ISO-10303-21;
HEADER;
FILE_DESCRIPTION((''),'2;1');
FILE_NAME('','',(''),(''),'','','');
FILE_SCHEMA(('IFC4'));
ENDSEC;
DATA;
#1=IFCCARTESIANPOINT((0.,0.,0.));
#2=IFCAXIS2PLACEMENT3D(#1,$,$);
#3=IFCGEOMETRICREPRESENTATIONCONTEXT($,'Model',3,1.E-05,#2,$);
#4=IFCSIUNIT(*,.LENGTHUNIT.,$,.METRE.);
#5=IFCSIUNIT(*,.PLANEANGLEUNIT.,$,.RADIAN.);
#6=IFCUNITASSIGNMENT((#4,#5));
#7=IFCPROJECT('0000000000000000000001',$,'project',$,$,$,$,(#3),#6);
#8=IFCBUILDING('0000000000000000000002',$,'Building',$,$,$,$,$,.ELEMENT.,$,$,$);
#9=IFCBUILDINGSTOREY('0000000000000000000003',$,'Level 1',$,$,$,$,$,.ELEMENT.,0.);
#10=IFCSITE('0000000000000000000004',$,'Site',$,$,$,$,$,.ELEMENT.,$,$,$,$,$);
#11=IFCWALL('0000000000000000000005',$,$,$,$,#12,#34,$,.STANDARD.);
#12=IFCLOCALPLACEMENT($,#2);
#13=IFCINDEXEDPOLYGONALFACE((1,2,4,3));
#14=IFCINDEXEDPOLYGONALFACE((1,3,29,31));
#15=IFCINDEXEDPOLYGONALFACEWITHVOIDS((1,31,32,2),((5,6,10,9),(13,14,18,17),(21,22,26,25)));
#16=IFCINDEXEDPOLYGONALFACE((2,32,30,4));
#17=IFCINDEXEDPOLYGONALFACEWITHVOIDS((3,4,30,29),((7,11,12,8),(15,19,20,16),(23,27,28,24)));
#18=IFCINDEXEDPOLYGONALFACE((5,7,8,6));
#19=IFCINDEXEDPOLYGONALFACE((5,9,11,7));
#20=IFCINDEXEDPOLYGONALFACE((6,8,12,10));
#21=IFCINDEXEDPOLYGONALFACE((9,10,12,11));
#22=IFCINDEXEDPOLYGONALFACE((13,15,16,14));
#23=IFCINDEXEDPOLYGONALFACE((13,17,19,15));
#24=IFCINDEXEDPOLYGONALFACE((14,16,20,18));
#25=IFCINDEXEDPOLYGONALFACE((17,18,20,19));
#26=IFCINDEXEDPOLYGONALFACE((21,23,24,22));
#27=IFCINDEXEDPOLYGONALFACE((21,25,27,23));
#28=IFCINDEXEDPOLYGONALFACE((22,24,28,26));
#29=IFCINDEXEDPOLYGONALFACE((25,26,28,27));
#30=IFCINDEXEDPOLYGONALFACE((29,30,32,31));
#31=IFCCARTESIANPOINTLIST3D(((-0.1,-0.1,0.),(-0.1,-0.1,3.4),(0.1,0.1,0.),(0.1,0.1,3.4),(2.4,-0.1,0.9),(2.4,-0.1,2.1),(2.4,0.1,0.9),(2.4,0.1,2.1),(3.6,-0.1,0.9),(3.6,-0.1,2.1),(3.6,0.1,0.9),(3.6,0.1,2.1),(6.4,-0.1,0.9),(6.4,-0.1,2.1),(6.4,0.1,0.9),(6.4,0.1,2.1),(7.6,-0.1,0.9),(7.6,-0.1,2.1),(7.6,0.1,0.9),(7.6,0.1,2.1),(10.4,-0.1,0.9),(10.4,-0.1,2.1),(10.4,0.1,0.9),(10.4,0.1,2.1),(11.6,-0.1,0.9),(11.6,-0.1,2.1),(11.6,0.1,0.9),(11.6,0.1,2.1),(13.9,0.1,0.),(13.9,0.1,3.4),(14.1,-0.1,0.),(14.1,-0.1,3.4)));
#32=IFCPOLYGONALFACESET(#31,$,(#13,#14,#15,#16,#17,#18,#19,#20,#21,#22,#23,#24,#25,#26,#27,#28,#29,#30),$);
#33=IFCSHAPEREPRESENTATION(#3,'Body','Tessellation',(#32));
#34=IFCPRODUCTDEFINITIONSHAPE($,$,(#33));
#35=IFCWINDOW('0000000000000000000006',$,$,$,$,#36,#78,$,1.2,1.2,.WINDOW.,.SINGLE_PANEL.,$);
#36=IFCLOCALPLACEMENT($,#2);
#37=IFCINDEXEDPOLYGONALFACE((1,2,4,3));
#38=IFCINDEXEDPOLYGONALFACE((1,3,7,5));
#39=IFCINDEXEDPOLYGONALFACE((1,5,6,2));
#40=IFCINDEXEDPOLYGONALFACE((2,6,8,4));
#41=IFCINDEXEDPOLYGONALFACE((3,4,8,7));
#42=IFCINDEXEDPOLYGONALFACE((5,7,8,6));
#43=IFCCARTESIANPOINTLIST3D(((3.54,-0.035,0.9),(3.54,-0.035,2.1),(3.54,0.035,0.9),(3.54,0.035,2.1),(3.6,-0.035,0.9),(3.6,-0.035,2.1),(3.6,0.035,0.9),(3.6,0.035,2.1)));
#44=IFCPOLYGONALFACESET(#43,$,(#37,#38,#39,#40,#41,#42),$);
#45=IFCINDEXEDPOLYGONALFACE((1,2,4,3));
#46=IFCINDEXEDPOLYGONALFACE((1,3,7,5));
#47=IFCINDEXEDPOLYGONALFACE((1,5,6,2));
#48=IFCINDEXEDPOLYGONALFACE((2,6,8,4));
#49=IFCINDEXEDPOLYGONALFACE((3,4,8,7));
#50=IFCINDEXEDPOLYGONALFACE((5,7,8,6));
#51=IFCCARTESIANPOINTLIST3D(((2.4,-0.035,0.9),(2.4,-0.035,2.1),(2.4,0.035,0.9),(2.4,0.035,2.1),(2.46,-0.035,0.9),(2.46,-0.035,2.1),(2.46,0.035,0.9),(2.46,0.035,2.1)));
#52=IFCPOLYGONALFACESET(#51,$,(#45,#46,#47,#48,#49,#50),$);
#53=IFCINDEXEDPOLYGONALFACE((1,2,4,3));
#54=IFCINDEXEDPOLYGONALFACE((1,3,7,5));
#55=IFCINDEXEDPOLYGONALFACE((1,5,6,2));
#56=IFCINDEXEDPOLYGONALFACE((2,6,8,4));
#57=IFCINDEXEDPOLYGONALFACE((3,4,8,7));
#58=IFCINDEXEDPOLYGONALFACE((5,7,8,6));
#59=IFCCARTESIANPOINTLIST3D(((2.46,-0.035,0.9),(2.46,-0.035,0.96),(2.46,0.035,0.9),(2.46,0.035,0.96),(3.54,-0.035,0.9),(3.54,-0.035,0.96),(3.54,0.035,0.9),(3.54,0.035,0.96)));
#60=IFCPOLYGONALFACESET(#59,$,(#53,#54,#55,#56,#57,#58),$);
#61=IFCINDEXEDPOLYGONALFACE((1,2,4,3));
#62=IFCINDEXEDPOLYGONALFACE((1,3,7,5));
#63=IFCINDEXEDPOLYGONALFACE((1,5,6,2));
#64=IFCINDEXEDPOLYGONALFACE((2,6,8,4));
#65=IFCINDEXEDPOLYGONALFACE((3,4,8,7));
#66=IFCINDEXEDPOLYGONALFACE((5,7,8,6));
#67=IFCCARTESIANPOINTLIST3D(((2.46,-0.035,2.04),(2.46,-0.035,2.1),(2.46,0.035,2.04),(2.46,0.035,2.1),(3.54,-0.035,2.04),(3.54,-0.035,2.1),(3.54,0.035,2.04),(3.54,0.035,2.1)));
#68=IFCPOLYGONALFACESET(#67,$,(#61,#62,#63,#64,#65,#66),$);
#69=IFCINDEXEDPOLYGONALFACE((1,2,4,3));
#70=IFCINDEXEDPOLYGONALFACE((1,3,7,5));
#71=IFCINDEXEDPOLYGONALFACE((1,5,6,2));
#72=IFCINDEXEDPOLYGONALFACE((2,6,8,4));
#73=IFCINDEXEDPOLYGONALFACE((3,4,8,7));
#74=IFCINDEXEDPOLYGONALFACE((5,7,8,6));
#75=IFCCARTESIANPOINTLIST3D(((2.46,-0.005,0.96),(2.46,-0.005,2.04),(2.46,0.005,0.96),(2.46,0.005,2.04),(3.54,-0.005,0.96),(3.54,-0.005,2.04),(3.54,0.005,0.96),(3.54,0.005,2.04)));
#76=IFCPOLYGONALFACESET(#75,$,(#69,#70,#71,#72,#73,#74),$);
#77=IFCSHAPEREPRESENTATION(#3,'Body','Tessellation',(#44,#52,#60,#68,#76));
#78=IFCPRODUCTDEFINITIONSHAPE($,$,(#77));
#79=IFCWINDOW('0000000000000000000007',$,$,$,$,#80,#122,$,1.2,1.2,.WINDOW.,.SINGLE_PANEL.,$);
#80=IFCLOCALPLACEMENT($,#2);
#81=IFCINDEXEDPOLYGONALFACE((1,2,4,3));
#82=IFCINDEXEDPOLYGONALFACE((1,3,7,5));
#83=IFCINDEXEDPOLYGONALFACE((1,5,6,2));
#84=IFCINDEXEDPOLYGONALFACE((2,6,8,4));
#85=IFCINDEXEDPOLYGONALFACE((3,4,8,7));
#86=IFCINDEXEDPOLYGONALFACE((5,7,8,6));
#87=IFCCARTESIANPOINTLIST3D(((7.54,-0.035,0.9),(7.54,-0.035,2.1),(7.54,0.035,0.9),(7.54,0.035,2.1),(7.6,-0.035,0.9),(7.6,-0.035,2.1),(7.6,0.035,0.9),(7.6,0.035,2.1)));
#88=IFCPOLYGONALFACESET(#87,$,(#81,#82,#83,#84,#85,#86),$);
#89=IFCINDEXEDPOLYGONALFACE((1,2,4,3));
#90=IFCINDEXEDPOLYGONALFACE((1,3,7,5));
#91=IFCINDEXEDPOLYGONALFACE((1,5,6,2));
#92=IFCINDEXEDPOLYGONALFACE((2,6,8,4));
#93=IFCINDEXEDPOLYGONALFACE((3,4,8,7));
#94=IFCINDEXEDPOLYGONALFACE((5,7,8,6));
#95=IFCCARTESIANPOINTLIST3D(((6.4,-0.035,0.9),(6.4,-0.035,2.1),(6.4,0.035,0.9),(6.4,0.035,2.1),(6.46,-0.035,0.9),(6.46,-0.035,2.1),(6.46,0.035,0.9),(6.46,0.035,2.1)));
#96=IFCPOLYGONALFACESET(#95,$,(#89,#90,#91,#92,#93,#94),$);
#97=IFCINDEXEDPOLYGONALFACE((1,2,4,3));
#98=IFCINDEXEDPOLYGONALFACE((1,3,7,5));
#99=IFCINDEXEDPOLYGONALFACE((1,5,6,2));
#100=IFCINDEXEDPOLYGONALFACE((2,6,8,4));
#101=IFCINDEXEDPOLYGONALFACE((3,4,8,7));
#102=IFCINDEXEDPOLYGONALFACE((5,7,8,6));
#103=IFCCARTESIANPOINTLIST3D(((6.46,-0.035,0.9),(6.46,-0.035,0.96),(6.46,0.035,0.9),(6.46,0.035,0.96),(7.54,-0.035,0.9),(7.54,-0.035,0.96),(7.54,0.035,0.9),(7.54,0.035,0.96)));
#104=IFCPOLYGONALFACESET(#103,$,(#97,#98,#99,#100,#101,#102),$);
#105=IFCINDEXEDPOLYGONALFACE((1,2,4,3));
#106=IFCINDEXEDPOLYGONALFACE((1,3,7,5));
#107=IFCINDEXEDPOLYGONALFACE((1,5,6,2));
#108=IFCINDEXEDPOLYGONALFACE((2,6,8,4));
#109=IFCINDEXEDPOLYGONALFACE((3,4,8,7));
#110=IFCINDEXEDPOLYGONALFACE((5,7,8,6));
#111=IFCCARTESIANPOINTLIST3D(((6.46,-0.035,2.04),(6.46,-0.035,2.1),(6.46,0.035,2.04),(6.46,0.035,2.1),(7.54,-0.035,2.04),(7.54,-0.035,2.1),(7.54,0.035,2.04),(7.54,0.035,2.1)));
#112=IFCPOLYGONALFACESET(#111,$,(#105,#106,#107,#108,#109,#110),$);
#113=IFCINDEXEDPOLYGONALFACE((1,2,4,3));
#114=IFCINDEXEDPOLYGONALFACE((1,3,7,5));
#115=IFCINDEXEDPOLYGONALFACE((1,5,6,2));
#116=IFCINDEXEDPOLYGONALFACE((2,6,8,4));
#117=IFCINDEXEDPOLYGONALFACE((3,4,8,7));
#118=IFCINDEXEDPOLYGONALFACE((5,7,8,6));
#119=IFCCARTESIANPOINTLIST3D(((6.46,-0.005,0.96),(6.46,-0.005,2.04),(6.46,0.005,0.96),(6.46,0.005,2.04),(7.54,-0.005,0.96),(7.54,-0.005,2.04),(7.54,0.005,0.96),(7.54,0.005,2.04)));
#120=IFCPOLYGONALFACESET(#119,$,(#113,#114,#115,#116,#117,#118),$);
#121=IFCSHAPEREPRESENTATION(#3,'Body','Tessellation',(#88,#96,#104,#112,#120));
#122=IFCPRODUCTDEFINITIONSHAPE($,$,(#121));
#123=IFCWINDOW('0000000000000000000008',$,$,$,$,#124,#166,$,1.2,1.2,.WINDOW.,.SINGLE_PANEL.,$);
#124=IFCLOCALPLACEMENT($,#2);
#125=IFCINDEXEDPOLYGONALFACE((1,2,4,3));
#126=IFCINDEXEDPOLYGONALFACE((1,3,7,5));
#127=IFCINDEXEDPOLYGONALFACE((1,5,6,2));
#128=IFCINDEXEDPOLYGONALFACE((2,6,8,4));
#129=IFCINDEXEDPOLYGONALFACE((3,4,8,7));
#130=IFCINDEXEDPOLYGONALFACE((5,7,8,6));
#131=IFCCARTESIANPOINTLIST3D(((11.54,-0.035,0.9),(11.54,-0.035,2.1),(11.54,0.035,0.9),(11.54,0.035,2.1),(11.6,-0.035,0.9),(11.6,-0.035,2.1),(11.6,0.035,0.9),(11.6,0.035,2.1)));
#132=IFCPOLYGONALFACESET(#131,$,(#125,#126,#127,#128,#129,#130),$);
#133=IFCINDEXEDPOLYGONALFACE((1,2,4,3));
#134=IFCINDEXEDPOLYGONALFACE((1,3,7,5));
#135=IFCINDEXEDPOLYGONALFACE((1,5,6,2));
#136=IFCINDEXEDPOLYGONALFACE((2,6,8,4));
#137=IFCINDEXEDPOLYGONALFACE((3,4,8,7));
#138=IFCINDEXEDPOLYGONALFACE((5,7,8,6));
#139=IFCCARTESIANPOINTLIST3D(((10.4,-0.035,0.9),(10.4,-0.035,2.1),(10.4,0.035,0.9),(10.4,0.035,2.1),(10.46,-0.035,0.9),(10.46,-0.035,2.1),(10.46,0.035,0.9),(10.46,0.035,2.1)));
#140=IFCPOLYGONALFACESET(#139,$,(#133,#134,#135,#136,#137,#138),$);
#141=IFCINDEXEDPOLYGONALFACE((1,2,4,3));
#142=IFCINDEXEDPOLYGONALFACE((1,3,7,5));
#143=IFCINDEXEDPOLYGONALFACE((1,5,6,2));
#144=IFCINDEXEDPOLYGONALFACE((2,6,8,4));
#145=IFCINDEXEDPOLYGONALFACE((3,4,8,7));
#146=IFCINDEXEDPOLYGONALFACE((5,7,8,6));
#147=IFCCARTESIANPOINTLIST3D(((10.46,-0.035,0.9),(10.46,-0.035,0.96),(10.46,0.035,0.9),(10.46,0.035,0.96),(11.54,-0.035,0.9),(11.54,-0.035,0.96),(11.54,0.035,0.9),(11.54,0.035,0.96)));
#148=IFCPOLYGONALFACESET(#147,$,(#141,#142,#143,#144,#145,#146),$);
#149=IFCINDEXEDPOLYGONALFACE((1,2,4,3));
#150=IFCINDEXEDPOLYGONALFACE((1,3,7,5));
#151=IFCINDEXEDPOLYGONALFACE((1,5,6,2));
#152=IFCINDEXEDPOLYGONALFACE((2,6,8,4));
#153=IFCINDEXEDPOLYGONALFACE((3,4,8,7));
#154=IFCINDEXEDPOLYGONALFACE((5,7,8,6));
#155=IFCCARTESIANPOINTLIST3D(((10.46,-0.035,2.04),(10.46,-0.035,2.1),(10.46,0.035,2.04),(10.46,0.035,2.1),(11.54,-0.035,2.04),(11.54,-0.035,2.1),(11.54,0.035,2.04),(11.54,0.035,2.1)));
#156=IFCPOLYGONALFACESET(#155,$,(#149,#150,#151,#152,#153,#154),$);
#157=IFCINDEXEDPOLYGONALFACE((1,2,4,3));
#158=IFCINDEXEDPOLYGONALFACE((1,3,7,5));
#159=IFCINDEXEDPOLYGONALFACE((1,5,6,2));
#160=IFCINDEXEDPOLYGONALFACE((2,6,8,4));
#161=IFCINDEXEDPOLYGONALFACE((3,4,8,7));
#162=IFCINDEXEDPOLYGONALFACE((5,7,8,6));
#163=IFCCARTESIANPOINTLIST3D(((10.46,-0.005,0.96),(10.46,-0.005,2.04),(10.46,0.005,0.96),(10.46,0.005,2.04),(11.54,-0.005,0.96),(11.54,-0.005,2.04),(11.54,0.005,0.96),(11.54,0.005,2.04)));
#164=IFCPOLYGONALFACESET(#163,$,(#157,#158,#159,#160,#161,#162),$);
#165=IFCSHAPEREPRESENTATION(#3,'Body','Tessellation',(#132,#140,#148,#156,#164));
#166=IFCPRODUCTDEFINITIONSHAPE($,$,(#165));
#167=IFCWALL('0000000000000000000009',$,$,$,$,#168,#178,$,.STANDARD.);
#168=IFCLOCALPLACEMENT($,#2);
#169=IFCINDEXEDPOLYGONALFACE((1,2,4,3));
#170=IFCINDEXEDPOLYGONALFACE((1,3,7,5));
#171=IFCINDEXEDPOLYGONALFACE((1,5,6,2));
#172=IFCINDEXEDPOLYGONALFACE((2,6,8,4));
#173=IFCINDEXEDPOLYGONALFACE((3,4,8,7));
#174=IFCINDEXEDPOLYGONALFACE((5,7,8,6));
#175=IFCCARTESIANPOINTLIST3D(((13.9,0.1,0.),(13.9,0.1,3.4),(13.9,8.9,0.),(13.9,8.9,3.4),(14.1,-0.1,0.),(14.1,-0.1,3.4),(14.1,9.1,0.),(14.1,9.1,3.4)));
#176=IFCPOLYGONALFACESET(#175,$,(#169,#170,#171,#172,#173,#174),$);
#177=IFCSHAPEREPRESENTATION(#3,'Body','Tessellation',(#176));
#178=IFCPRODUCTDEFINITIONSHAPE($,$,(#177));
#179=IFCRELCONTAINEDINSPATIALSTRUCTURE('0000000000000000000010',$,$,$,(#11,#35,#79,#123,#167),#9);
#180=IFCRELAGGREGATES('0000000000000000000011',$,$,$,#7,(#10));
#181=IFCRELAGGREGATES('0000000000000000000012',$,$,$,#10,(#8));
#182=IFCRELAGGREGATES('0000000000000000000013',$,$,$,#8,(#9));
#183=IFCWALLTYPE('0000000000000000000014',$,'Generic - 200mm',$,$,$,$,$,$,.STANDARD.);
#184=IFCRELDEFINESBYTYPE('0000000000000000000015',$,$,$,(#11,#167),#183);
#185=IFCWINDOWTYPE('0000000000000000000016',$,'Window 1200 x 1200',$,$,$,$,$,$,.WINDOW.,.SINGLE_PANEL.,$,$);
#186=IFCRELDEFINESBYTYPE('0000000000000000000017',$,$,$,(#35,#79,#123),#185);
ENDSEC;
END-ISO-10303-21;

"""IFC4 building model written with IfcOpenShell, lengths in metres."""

from ifc_helpers import new_model, si_unit, frame, frame_2d, origin, origin_with_axes, origin_2d, place, context, project, spatial, polyline, rectangle, outline, extrude, type_object, element, fill, save


model = new_model("IFC4")

# Units and contexts
model_context = context("Model", 3, precision=1e-05, world=origin())
ifc_project = project(units=[si_unit("LENGTHUNIT", "METRE"), si_unit("PLANEANGLEUNIT", "RADIAN")], contexts=[model_context])

# Site, building, storey
site = spatial("IfcSite", under=ifc_project, Name="Site", CompositionType="ELEMENT")
building = spatial("IfcBuilding", under=site, Name="Building", CompositionType="ELEMENT")
storey = spatial("IfcBuildingStorey", under=building, Name="Level 1", CompositionType="ELEMENT", Elevation=0.0)

# Wall, openings, windows
wall_type = type_object("IfcWallType", Name="Generic - 200mm", PredefinedType="STANDARD")
wall_1_placement = place(None, frame((14.0, 0.0, 0.0), z_axis=(0.0, 0.0, 1.0), x_axis=(-1.0, 0.0, 0.0)))
wall_1 = element("IfcWall", 1, at=wall_1_placement, inside=storey, type_object=wall_type, PredefinedType="STANDARD", context=model_context, shape_type="SweptSolid", body=[
    extrude(outline(polyline([(0.1, -0.1), (13.9, -0.1), (14.1, 0.1), (-0.1, 0.1), (0.1, -0.1)])), origin(), (0.0, 0.0, 1.0), 3.4),
])
opening_1_placement = place(wall_1_placement, frame((11.0, 0.0, 0.9), z_axis=(0.0, 0.0, 1.0), x_axis=(1.0, 0.0, 0.0)))
opening_1 = element("IfcOpeningElement", 2, at=opening_1_placement, cuts=wall_1, PredefinedType="OPENING", context=model_context, shape_type="SweptSolid", body=[
    extrude(rectangle(XDim=1.2, YDim=0.202, at=origin_2d()), origin(), (0.0, 0.0, 1.0), 1.2),
])
opening_2_placement = place(wall_1_placement, frame((7.0, 0.0, 0.9), z_axis=(0.0, 0.0, 1.0), x_axis=(1.0, 0.0, 0.0)))
opening_2 = element("IfcOpeningElement", 3, at=opening_2_placement, cuts=wall_1, PredefinedType="OPENING", context=model_context, shape_type="SweptSolid", body=[
    extrude(rectangle(XDim=1.2, YDim=0.202, at=origin_2d()), origin(), (0.0, 0.0, 1.0), 1.2),
])
opening_3_placement = place(wall_1_placement, frame((3.0, 0.0, 0.9), z_axis=(0.0, 0.0, 1.0), x_axis=(1.0, 0.0, 0.0)))
opening_3 = element("IfcOpeningElement", 4, at=opening_3_placement, cuts=wall_1, PredefinedType="OPENING", context=model_context, shape_type="SweptSolid", body=[
    extrude(rectangle(XDim=1.2, YDim=0.202, at=origin_2d()), origin(), (0.0, 0.0, 1.0), 1.2),
])
window_type = type_object("IfcWindowType", Name="Window 1200 x 1200", PartitioningType="SINGLE_PANEL", PredefinedType="WINDOW")
window_1_placement = place(opening_1_placement, origin_with_axes())
window_1 = element("IfcWindow", 5, at=window_1_placement, inside=storey, type_object=window_type, OverallHeight=1.2, OverallWidth=1.2, PartitioningType="SINGLE_PANEL", PredefinedType="WINDOW", context=model_context, shape_type="SweptSolid", body=[
    extrude(rectangle(XDim=0.06, YDim=0.07, at=frame_2d((-0.57, 0.0))), origin(), (0.0, 0.0, 1.0), 1.2),
    extrude(rectangle(XDim=0.06, YDim=0.07, at=frame_2d((0.57, 0.0))), origin(), (0.0, 0.0, 1.0), 1.2),
    extrude(rectangle(XDim=1.08, YDim=0.07, at=origin_2d()), origin(), (0.0, 0.0, 1.0), 0.06),
    extrude(rectangle(XDim=1.08, YDim=0.07, at=origin_2d()), frame((0.0, 0.0, 1.14)), (0.0, 0.0, 1.0), 0.06),
    extrude(rectangle(XDim=1.08, YDim=0.01, at=origin_2d()), frame((0.0, 0.0, 0.06)), (0.0, 0.0, 1.0), 1.08),
])
fill(opening_1, window_1)
window_2_placement = place(opening_2_placement, origin_with_axes())
window_2 = element("IfcWindow", 6, at=window_2_placement, inside=storey, type_object=window_type, OverallHeight=1.2, OverallWidth=1.2, PartitioningType="SINGLE_PANEL", PredefinedType="WINDOW", context=model_context, shape_type="SweptSolid", body=[
    extrude(rectangle(XDim=0.06, YDim=0.07, at=frame_2d((-0.57, 0.0))), origin(), (0.0, 0.0, 1.0), 1.2),
    extrude(rectangle(XDim=0.06, YDim=0.07, at=frame_2d((0.57, 0.0))), origin(), (0.0, 0.0, 1.0), 1.2),
    extrude(rectangle(XDim=1.08, YDim=0.07, at=origin_2d()), origin(), (0.0, 0.0, 1.0), 0.06),
    extrude(rectangle(XDim=1.08, YDim=0.07, at=origin_2d()), frame((0.0, 0.0, 1.14)), (0.0, 0.0, 1.0), 0.06),
    extrude(rectangle(XDim=1.08, YDim=0.01, at=origin_2d()), frame((0.0, 0.0, 0.06)), (0.0, 0.0, 1.0), 1.08),
])
fill(opening_2, window_2)
window_3_placement = place(opening_3_placement, origin_with_axes())
window_3 = element("IfcWindow", 7, at=window_3_placement, inside=storey, type_object=window_type, OverallHeight=1.2, OverallWidth=1.2, PartitioningType="SINGLE_PANEL", PredefinedType="WINDOW", context=model_context, shape_type="SweptSolid", body=[
    extrude(rectangle(XDim=0.06, YDim=0.07, at=frame_2d((-0.57, 0.0))), origin(), (0.0, 0.0, 1.0), 1.2),
    extrude(rectangle(XDim=0.06, YDim=0.07, at=frame_2d((0.57, 0.0))), origin(), (0.0, 0.0, 1.0), 1.2),
    extrude(rectangle(XDim=1.08, YDim=0.07, at=origin_2d()), origin(), (0.0, 0.0, 1.0), 0.06),
    extrude(rectangle(XDim=1.08, YDim=0.07, at=origin_2d()), frame((0.0, 0.0, 1.14)), (0.0, 0.0, 1.0), 0.06),
    extrude(rectangle(XDim=1.08, YDim=0.01, at=origin_2d()), frame((0.0, 0.0, 0.06)), (0.0, 0.0, 1.0), 1.08),
])
fill(opening_3, window_3)

# Wall
wall_2_placement = place(None, frame((14.0, 9.0, 0.0), z_axis=(0.0, 0.0, 1.0), x_axis=(0.0, -1.0, 0.0)))
element("IfcWall", 8, at=wall_2_placement, inside=storey, type_object=wall_type, PredefinedType="STANDARD", context=model_context, shape_type="SweptSolid", body=[
    extrude(outline(polyline([(0.1, -0.1), (8.9, -0.1), (9.1, 0.1), (-0.1, 0.1), (0.1, -0.1)])), origin(), (0.0, 0.0, 1.0), 3.4),
])

save(model, "model.ifc")
